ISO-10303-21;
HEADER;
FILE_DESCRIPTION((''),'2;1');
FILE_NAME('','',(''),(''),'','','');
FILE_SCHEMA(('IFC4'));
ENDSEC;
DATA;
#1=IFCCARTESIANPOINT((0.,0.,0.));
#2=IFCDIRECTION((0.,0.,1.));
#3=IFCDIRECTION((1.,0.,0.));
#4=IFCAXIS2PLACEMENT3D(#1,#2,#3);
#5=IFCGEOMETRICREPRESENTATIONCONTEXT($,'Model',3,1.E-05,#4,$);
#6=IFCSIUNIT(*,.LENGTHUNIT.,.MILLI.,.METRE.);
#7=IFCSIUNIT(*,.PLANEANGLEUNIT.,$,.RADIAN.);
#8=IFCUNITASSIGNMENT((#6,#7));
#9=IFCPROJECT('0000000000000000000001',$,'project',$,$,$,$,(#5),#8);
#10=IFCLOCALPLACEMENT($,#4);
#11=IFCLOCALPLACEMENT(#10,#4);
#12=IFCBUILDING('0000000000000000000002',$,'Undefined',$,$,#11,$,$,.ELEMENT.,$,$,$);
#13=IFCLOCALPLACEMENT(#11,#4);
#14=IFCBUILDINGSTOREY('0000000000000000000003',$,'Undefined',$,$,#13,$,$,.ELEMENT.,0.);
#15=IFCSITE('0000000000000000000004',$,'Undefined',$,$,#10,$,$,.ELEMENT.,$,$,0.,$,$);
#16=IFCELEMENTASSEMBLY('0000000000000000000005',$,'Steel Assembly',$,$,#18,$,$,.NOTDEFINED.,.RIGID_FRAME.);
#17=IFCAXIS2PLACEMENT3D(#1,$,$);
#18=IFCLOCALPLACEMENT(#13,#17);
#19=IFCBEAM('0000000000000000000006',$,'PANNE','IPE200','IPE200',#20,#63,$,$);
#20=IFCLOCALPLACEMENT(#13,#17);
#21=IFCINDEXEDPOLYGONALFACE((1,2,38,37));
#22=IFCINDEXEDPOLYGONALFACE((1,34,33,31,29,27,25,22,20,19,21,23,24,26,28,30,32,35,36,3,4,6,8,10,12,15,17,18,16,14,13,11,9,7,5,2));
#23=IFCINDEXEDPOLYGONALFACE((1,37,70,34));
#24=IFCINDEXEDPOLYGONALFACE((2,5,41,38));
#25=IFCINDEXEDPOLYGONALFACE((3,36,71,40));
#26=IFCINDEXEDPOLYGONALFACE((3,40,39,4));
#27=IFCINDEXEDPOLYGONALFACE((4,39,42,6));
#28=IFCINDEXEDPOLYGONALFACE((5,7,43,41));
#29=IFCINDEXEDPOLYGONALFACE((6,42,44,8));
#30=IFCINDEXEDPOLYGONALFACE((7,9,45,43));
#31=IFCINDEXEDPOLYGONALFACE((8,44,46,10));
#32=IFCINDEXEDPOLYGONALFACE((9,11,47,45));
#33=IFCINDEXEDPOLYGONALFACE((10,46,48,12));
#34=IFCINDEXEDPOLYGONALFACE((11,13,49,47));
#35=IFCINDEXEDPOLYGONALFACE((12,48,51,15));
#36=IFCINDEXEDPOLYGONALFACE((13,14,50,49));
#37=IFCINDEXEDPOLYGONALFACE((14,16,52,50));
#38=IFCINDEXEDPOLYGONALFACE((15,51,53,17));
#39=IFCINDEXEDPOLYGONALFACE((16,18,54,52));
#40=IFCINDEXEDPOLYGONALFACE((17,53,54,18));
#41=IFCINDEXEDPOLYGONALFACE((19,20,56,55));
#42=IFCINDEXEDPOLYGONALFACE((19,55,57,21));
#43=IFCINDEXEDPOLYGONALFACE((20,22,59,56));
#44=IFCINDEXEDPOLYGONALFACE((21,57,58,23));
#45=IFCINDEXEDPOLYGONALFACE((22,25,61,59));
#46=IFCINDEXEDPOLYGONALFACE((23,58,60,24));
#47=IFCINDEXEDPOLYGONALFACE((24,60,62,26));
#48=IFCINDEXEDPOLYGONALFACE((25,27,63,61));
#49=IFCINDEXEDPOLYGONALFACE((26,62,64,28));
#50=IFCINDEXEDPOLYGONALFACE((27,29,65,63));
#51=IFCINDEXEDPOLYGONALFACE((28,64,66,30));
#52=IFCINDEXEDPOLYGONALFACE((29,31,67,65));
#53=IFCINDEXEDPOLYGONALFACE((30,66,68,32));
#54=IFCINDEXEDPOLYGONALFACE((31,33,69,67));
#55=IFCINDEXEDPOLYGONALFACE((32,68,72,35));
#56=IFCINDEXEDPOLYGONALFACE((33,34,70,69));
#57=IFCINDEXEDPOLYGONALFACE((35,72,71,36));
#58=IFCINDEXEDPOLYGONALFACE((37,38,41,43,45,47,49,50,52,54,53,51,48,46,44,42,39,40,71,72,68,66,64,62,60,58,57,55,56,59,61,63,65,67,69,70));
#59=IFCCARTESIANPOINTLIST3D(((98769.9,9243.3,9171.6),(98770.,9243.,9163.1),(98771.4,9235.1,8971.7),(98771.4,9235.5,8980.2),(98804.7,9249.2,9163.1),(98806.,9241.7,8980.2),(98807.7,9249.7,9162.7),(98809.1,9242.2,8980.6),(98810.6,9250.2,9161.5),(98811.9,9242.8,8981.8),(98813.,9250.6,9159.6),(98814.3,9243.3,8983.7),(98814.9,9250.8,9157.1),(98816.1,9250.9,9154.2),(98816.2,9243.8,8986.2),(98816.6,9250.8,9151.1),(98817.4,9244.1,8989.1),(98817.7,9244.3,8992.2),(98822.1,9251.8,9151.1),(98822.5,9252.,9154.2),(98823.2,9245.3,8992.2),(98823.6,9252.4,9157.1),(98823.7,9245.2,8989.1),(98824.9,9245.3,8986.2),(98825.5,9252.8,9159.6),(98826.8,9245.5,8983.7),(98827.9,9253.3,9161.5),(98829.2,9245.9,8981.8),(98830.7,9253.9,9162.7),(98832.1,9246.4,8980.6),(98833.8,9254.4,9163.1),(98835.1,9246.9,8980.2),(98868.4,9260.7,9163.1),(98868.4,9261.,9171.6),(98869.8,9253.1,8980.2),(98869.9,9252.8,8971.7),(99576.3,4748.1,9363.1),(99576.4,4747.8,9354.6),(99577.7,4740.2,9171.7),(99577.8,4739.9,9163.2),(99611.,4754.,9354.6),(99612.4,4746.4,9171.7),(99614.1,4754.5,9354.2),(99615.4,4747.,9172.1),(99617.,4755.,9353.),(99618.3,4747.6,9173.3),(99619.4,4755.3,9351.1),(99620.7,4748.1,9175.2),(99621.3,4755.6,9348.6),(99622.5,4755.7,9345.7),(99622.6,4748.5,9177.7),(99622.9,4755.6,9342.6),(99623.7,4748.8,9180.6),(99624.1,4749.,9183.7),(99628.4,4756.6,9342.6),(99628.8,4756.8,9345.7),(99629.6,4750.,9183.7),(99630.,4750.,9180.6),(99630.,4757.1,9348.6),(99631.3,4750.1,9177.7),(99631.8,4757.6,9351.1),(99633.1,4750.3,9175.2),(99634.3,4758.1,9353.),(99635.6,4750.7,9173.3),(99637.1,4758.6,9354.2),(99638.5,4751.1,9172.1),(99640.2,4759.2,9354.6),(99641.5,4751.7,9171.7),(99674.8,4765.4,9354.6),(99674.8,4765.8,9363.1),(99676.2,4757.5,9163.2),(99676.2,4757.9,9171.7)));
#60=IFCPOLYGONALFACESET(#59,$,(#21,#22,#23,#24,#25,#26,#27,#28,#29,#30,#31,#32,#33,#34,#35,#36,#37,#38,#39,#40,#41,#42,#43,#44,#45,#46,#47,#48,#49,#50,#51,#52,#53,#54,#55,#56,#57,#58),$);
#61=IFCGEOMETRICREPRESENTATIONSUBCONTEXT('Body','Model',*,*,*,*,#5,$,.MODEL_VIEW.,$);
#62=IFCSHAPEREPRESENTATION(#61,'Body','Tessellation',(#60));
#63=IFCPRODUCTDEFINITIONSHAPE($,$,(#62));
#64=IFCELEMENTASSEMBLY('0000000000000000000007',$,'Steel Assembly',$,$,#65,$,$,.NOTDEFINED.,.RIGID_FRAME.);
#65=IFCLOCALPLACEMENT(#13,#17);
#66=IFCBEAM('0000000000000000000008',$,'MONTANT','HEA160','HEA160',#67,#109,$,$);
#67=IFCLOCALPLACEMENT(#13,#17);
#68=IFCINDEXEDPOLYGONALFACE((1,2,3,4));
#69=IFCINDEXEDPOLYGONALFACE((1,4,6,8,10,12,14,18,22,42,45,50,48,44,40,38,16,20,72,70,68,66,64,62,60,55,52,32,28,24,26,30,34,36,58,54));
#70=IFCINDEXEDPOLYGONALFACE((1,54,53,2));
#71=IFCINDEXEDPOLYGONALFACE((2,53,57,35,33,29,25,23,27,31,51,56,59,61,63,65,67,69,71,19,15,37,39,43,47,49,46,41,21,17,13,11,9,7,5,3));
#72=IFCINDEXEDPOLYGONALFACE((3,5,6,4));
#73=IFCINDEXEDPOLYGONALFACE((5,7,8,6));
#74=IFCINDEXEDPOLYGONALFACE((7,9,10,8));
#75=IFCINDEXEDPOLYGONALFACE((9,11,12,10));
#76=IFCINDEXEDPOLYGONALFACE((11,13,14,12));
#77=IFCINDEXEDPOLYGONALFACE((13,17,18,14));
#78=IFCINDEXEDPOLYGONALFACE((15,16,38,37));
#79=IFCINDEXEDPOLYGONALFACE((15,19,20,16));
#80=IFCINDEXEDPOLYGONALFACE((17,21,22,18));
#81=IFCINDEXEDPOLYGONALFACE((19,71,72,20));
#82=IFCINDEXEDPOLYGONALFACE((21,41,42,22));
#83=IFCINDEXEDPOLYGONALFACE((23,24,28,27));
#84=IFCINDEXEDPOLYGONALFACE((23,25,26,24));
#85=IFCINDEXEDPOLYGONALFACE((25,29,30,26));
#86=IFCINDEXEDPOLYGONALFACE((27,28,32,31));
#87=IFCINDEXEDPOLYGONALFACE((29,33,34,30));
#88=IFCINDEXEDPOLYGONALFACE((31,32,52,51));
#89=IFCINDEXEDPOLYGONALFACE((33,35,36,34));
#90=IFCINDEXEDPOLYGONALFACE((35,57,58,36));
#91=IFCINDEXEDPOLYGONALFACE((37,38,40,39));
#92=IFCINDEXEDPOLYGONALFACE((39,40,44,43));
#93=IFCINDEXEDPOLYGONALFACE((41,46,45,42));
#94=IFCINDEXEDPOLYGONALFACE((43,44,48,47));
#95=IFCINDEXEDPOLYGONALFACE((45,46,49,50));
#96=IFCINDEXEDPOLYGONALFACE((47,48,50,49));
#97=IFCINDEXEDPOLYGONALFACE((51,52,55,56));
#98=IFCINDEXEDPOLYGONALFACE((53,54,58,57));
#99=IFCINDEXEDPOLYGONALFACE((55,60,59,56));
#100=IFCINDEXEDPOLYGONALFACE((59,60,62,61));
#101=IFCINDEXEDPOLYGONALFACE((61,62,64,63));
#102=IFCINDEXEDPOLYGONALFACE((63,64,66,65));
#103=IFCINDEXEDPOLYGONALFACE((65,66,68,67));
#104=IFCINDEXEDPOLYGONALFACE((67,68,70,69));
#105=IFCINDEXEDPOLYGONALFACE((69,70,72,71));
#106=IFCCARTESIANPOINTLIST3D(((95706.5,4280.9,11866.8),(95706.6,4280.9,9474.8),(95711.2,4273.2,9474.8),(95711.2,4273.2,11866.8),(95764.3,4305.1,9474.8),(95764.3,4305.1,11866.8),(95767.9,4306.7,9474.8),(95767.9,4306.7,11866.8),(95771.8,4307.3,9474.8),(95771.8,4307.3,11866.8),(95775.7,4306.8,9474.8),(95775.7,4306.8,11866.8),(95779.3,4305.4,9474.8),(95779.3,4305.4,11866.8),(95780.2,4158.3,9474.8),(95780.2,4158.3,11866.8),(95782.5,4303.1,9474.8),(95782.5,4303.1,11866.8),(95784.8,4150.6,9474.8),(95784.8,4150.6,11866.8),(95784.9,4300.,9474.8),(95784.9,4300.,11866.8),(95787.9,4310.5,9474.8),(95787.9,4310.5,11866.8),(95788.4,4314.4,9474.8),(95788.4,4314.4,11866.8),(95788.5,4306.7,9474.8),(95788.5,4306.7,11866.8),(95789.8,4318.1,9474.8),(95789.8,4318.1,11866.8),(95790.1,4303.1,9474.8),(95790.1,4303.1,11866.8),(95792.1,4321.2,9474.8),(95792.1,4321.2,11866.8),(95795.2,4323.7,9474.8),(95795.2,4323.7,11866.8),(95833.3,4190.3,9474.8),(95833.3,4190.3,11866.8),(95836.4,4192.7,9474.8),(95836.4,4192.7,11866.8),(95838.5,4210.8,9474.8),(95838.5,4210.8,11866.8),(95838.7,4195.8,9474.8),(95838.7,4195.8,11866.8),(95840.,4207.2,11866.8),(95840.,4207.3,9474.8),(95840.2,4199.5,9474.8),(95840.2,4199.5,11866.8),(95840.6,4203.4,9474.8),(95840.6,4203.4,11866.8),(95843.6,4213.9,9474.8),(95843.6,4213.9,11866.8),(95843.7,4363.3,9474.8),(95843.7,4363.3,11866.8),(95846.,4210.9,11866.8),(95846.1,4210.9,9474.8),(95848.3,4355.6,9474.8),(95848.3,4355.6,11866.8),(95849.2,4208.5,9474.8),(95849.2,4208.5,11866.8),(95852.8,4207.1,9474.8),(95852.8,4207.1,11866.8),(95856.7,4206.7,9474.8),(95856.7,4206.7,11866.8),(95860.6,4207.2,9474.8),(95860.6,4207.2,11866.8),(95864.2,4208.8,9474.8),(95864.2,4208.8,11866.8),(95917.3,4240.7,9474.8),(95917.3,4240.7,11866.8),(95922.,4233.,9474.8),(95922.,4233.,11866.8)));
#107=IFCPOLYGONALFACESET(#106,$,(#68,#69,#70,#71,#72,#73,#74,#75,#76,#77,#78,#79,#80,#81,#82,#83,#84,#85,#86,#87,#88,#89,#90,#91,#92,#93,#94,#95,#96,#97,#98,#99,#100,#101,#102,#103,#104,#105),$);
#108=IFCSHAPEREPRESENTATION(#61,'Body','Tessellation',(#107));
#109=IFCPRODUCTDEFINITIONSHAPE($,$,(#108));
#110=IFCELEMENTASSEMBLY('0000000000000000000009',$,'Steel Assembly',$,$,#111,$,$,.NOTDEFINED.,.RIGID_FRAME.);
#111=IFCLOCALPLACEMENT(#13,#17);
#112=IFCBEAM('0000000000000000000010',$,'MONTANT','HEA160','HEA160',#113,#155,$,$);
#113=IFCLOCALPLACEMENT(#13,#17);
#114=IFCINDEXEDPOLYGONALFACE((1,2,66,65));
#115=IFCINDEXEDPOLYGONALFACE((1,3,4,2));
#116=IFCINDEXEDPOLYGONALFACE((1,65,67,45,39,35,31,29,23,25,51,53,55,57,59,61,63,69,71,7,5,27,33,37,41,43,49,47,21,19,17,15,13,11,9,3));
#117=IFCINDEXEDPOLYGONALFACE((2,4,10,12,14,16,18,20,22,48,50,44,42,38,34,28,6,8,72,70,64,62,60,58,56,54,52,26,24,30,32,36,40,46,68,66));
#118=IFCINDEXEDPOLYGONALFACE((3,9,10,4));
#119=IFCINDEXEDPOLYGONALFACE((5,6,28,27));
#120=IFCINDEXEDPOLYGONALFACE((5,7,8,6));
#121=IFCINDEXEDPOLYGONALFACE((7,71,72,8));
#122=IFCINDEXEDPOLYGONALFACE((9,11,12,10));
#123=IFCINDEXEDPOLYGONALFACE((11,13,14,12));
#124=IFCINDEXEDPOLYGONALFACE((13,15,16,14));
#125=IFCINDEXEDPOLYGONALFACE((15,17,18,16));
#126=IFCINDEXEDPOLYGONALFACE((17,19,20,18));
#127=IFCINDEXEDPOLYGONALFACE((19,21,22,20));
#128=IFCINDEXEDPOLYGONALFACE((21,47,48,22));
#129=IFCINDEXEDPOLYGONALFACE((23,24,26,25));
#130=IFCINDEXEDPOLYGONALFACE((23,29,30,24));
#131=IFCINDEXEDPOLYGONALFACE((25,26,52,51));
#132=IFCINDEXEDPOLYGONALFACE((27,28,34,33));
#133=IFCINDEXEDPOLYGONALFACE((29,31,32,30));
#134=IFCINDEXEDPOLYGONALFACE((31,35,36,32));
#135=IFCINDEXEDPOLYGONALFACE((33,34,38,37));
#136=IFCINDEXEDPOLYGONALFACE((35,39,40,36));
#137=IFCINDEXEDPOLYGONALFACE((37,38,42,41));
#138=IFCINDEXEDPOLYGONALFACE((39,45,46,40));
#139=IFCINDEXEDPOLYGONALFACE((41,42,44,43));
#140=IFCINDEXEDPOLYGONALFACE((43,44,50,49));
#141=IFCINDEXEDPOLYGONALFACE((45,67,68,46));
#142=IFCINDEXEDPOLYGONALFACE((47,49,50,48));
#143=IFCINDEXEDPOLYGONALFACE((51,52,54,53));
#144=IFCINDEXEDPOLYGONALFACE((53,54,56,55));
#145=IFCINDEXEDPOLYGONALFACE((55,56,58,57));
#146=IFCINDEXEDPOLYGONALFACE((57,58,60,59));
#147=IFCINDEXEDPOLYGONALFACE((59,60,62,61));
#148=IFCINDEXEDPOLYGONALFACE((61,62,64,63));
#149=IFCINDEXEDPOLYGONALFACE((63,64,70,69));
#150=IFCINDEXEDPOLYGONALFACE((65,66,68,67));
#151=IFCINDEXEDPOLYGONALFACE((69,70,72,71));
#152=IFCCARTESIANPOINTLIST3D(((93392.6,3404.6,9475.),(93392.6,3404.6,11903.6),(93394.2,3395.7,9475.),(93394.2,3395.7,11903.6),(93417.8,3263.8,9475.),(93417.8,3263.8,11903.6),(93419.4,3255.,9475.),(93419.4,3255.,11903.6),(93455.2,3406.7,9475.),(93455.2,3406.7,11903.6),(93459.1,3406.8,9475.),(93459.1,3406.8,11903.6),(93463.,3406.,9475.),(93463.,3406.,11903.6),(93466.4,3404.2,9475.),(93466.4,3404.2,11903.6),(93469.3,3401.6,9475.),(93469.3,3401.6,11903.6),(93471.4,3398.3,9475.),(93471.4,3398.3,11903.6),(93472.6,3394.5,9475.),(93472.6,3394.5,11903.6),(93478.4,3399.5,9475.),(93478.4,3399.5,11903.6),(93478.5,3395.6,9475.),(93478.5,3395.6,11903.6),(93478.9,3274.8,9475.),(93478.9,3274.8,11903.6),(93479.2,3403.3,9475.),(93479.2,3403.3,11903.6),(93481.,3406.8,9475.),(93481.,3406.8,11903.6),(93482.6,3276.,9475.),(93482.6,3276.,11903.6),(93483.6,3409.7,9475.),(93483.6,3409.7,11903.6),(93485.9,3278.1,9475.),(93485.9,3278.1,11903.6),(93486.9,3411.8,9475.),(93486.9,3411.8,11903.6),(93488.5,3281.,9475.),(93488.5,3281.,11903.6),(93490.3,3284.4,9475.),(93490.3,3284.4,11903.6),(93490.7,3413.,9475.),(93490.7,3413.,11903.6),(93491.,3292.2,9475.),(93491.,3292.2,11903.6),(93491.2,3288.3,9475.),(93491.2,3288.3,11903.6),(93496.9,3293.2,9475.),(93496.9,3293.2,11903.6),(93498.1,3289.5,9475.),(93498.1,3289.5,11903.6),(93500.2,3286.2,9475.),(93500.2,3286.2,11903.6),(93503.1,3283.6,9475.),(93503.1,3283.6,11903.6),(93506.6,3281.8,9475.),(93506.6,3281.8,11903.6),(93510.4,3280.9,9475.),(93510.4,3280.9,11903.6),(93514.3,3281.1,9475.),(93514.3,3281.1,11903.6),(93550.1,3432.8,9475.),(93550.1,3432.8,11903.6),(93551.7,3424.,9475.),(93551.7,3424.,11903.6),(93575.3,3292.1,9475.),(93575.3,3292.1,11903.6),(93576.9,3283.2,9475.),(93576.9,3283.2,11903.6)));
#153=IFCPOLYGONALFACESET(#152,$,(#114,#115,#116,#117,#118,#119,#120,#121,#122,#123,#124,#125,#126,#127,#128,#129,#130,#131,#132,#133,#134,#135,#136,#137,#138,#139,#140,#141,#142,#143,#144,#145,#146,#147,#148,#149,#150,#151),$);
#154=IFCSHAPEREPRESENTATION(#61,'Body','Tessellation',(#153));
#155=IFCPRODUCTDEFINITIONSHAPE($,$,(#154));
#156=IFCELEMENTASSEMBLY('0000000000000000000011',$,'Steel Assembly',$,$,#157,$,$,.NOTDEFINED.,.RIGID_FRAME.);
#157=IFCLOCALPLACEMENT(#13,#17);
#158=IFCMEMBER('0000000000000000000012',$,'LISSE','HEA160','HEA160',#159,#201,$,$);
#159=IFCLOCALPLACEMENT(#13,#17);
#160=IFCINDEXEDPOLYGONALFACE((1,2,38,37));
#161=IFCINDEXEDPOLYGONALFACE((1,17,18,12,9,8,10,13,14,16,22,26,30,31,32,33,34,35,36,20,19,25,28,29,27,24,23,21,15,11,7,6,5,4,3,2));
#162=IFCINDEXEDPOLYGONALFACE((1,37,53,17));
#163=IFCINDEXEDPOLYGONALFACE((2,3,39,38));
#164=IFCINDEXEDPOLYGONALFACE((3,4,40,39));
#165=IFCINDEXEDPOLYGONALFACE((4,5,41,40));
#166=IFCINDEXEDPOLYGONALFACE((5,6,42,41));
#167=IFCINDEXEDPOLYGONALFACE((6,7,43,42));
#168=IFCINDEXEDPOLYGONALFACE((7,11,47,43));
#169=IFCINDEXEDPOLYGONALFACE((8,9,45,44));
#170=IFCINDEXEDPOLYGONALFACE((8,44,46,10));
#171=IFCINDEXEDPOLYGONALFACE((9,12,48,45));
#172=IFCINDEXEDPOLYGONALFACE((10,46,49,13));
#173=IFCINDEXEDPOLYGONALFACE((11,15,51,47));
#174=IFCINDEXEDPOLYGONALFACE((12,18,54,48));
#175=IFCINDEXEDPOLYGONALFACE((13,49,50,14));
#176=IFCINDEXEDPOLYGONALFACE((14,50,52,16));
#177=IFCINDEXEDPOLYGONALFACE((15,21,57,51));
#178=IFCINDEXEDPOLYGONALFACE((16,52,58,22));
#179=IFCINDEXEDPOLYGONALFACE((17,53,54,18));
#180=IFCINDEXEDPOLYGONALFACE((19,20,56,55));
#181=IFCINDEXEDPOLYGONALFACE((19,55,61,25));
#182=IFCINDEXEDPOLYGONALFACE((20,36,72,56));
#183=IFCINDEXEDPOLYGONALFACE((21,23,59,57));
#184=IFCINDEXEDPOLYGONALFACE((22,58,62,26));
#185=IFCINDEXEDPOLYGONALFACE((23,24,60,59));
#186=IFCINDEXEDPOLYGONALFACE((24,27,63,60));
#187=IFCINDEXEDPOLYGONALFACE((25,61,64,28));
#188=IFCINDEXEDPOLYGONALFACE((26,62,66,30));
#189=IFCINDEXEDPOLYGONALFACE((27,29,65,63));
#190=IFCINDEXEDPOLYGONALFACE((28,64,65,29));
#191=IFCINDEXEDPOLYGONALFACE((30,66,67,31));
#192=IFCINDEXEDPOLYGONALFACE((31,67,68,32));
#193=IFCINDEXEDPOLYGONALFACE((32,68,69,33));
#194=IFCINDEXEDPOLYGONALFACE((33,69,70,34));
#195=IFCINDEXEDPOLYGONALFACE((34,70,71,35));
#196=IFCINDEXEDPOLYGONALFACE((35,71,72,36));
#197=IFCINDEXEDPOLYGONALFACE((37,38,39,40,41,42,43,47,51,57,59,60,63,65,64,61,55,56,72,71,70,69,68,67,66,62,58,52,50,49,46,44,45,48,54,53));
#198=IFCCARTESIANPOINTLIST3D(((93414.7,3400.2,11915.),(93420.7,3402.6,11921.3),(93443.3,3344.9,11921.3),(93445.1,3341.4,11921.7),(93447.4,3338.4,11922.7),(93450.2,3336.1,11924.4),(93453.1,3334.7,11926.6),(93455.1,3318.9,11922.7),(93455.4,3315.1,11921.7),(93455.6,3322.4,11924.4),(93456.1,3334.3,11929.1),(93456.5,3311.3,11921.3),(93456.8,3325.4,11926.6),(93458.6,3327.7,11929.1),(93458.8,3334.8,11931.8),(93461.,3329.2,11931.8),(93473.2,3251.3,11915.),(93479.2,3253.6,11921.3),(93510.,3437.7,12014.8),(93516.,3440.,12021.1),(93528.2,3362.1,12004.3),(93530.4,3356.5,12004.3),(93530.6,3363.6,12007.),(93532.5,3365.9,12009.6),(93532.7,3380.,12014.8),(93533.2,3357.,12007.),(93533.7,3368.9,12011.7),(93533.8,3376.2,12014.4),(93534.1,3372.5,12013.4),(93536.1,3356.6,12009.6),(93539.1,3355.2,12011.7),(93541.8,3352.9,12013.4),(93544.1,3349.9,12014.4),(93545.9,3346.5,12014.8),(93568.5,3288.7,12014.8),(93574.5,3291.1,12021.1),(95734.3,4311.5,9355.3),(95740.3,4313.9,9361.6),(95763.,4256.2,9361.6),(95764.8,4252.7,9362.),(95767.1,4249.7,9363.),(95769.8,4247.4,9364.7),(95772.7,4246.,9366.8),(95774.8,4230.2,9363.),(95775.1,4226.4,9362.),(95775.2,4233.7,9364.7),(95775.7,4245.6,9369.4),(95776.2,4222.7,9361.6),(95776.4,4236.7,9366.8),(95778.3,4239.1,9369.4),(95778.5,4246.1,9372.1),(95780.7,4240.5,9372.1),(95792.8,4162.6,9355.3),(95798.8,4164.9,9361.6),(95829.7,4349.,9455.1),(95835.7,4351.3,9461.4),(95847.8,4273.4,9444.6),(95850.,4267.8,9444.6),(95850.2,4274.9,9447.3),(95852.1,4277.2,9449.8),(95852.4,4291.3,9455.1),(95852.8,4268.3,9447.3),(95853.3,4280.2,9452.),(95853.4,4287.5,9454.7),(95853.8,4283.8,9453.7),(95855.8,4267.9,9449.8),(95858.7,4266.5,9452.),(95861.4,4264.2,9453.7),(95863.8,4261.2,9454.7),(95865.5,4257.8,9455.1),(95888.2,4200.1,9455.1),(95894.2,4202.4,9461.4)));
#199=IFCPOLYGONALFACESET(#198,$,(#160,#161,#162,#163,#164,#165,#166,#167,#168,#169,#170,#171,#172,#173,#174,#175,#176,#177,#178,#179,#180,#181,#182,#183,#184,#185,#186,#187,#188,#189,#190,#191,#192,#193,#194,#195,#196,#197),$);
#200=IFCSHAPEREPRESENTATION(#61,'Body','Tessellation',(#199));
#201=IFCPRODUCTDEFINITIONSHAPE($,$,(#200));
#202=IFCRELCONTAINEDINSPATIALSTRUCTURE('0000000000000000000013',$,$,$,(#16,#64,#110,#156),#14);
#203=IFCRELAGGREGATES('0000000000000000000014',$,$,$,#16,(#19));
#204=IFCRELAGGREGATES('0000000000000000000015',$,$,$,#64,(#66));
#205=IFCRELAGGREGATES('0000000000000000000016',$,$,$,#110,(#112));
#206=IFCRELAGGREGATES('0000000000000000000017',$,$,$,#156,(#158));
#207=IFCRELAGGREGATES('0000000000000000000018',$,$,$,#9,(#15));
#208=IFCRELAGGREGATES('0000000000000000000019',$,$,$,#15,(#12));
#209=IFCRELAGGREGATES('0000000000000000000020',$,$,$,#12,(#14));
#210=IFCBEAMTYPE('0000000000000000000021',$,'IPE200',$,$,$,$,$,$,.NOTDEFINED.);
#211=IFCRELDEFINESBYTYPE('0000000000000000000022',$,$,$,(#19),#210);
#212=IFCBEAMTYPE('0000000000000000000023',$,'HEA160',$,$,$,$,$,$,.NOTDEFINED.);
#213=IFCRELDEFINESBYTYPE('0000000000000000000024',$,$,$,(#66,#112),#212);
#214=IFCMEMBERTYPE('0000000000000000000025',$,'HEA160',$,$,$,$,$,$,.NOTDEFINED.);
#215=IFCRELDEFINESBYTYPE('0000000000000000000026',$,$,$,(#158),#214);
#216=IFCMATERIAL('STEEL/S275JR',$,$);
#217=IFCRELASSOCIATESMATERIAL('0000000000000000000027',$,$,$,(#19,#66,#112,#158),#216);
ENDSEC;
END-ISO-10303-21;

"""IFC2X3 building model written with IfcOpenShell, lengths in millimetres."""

from ifc_helpers import new_model, si_unit, frame, origin_with_axes, origin_2d_with_axis, place, context, subcontext, project, spatial, i_section, extrude, material, type_object, element, aggregate, save


model = new_model("IFC2X3")

# Units and contexts
model_context = context("Model", 3, precision=1e-05, world=origin_with_axes())
body_context = subcontext(model_context, "Body", "Model", "MODEL_VIEW")
ifc_project = project(units=[si_unit("LENGTHUNIT", "METRE", prefix="MILLI"), si_unit("PLANEANGLEUNIT", "RADIAN")], contexts=[model_context])

# Site, building, storey
site_placement = place(None, origin_with_axes())
site = spatial("IfcSite", under=ifc_project, at=site_placement, Name="Undefined", CompositionType="ELEMENT", RefElevation=0.0)
building_placement = place(site_placement, origin_with_axes())
building = spatial("IfcBuilding", under=site, at=building_placement, Name="Undefined", CompositionType="ELEMENT")
storey_placement = place(building_placement, origin_with_axes())
storey = spatial("IfcBuildingStorey", under=building, at=storey_placement, Name="Undefined", CompositionType="ELEMENT", Elevation=0.0)

# Shared definitions
ifc_material = material(Name="STEEL/S275JR")

# Element assemblies, beams
beam_type_1 = type_object("IfcBeamType", Name="IPE200", PredefinedType="NOTDEFINED")
assembly_1_placement = place(storey_placement, origin_with_axes())
assembly_1 = element("IfcElementAssembly", 1, at=assembly_1_placement, inside=storey, Name="Steel Assembly", AssemblyPlace="NOTDEFINED", PredefinedType="RIGID_FRAME")
beam_1_placement = place(assembly_1_placement, frame((99626.3, 4752.8, 9263.2), z_axis=(-0.007397, 0.041236, 0.999122), x_axis=(-0.176411, 0.983425, -0.041894)))
beam_1 = element("IfcBeam", 2, at=beam_1_placement, type_object=beam_type_1, material=ifc_material, Name="PANNE", Description="IPE200", ObjectType="IPE200", context=body_context, shape_type="SweptSolid", body=[
    extrude(i_section(OverallWidth=100.0, OverallDepth=200.0, WebThickness=5.6, FlangeThickness=8.5, FilletRadius=12.0, at=origin_2d_with_axis()), frame((4571.0, 0.0, 0.0), z_axis=(-1.0, 0.0, 0.0), x_axis=(0.0, -1.0, 0.0)), (0.0, 0.0, 1.0), 4571.0),
])
aggregate(assembly_1, [beam_1])
assembly_2_placement = place(storey_placement, origin_with_axes())
assembly_2 = element("IfcElementAssembly", 3, at=assembly_2_placement, inside=storey, Name="Steel Assembly", AssemblyPlace="NOTDEFINED", PredefinedType="RIGID_FRAME")
beam_type_2 = type_object("IfcBeamType", Name="HEA160", PredefinedType="NOTDEFINED")
beam_2_placement = place(assembly_2_placement, frame((95814.3, 4257.0, 11866.8), z_axis=(-0.514969, 0.857209, -0.000001), x_axis=(0.000002, 0.0, -1.0)))
beam_2 = element("IfcBeam", 4, at=beam_2_placement, type_object=beam_type_2, material=ifc_material, Name="MONTANT", Description="HEA160", ObjectType="HEA160", context=body_context, shape_type="SweptSolid", body=[
    extrude(i_section(OverallWidth=160.0, OverallDepth=152.0, WebThickness=6.0, FlangeThickness=9.0, FilletRadius=15.0, at=origin_2d_with_axis()), frame((2392.0, 0.0, 0.0), z_axis=(-1.0, 0.0, 0.0), x_axis=(0.0, -1.0, 0.0)), (0.0, 0.0, 1.0), 2392.0),
])
aggregate(assembly_2, [beam_2])
assembly_3_placement = place(storey_placement, origin_with_axes())
assembly_3 = element("IfcElementAssembly", 5, at=assembly_3_placement, inside=storey, Name="Steel Assembly", AssemblyPlace="NOTDEFINED", PredefinedType="RIGID_FRAME")
beam_3_placement = place(assembly_3_placement, frame((93484.8, 3343.9, 11903.6), z_axis=(-0.176397, 0.984319, 0.0), x_axis=(0.0, 0.0, -1.0)))
beam_3 = element("IfcBeam", 6, at=beam_3_placement, type_object=beam_type_2, material=ifc_material, Name="MONTANT", Description="HEA160", ObjectType="HEA160", context=body_context, shape_type="SweptSolid", body=[
    extrude(i_section(OverallWidth=160.0, OverallDepth=152.0, WebThickness=6.0, FlangeThickness=9.0, FilletRadius=15.0, at=origin_2d_with_axis()), frame((2428.6, 0.0, 0.0), z_axis=(-1.0, 0.0, 0.0), x_axis=(0.0, -1.0, 0.0)), (0.0, 0.0, 1.0), 2428.6),
])
aggregate(assembly_3, [beam_3])

# Element assembly, member
assembly_4_placement = place(storey_placement, origin_with_axes())
assembly_4 = element("IfcElementAssembly", 7, at=assembly_4_placement, inside=storey, Name="Steel Assembly", AssemblyPlace="NOTDEFINED", PredefinedType="RIGID_FRAME")
member_type_1 = type_object("IfcMemberType", Name="HEA160", PredefinedType="NOTDEFINED")
member_1_placement = place(assembly_4_placement, frame((93494.6, 3345.6, 11968.1), z_axis=(0.666872, 0.26199, 0.697597), x_axis=(0.649288, 0.255082, -0.71649)))
member_1 = element("IfcMember", 8, at=member_1_placement, type_object=member_type_1, material=ifc_material, Name="LISSE", Description="HEA160", ObjectType="HEA160", context=body_context, shape_type="SweptSolid", body=[
    extrude(i_section(OverallWidth=160.0, OverallDepth=152.0, WebThickness=6.0, FlangeThickness=9.0, FilletRadius=15.0, at=origin_2d_with_axis()), frame((3572.6, 0.0, 0.0), z_axis=(-1.0, 0.0, 0.0), x_axis=(0.0, -1.0, 0.0)), (0.0, 0.0, 1.0), 3572.6),
])
aggregate(assembly_4, [member_1])

save(model, "model.ifc")
